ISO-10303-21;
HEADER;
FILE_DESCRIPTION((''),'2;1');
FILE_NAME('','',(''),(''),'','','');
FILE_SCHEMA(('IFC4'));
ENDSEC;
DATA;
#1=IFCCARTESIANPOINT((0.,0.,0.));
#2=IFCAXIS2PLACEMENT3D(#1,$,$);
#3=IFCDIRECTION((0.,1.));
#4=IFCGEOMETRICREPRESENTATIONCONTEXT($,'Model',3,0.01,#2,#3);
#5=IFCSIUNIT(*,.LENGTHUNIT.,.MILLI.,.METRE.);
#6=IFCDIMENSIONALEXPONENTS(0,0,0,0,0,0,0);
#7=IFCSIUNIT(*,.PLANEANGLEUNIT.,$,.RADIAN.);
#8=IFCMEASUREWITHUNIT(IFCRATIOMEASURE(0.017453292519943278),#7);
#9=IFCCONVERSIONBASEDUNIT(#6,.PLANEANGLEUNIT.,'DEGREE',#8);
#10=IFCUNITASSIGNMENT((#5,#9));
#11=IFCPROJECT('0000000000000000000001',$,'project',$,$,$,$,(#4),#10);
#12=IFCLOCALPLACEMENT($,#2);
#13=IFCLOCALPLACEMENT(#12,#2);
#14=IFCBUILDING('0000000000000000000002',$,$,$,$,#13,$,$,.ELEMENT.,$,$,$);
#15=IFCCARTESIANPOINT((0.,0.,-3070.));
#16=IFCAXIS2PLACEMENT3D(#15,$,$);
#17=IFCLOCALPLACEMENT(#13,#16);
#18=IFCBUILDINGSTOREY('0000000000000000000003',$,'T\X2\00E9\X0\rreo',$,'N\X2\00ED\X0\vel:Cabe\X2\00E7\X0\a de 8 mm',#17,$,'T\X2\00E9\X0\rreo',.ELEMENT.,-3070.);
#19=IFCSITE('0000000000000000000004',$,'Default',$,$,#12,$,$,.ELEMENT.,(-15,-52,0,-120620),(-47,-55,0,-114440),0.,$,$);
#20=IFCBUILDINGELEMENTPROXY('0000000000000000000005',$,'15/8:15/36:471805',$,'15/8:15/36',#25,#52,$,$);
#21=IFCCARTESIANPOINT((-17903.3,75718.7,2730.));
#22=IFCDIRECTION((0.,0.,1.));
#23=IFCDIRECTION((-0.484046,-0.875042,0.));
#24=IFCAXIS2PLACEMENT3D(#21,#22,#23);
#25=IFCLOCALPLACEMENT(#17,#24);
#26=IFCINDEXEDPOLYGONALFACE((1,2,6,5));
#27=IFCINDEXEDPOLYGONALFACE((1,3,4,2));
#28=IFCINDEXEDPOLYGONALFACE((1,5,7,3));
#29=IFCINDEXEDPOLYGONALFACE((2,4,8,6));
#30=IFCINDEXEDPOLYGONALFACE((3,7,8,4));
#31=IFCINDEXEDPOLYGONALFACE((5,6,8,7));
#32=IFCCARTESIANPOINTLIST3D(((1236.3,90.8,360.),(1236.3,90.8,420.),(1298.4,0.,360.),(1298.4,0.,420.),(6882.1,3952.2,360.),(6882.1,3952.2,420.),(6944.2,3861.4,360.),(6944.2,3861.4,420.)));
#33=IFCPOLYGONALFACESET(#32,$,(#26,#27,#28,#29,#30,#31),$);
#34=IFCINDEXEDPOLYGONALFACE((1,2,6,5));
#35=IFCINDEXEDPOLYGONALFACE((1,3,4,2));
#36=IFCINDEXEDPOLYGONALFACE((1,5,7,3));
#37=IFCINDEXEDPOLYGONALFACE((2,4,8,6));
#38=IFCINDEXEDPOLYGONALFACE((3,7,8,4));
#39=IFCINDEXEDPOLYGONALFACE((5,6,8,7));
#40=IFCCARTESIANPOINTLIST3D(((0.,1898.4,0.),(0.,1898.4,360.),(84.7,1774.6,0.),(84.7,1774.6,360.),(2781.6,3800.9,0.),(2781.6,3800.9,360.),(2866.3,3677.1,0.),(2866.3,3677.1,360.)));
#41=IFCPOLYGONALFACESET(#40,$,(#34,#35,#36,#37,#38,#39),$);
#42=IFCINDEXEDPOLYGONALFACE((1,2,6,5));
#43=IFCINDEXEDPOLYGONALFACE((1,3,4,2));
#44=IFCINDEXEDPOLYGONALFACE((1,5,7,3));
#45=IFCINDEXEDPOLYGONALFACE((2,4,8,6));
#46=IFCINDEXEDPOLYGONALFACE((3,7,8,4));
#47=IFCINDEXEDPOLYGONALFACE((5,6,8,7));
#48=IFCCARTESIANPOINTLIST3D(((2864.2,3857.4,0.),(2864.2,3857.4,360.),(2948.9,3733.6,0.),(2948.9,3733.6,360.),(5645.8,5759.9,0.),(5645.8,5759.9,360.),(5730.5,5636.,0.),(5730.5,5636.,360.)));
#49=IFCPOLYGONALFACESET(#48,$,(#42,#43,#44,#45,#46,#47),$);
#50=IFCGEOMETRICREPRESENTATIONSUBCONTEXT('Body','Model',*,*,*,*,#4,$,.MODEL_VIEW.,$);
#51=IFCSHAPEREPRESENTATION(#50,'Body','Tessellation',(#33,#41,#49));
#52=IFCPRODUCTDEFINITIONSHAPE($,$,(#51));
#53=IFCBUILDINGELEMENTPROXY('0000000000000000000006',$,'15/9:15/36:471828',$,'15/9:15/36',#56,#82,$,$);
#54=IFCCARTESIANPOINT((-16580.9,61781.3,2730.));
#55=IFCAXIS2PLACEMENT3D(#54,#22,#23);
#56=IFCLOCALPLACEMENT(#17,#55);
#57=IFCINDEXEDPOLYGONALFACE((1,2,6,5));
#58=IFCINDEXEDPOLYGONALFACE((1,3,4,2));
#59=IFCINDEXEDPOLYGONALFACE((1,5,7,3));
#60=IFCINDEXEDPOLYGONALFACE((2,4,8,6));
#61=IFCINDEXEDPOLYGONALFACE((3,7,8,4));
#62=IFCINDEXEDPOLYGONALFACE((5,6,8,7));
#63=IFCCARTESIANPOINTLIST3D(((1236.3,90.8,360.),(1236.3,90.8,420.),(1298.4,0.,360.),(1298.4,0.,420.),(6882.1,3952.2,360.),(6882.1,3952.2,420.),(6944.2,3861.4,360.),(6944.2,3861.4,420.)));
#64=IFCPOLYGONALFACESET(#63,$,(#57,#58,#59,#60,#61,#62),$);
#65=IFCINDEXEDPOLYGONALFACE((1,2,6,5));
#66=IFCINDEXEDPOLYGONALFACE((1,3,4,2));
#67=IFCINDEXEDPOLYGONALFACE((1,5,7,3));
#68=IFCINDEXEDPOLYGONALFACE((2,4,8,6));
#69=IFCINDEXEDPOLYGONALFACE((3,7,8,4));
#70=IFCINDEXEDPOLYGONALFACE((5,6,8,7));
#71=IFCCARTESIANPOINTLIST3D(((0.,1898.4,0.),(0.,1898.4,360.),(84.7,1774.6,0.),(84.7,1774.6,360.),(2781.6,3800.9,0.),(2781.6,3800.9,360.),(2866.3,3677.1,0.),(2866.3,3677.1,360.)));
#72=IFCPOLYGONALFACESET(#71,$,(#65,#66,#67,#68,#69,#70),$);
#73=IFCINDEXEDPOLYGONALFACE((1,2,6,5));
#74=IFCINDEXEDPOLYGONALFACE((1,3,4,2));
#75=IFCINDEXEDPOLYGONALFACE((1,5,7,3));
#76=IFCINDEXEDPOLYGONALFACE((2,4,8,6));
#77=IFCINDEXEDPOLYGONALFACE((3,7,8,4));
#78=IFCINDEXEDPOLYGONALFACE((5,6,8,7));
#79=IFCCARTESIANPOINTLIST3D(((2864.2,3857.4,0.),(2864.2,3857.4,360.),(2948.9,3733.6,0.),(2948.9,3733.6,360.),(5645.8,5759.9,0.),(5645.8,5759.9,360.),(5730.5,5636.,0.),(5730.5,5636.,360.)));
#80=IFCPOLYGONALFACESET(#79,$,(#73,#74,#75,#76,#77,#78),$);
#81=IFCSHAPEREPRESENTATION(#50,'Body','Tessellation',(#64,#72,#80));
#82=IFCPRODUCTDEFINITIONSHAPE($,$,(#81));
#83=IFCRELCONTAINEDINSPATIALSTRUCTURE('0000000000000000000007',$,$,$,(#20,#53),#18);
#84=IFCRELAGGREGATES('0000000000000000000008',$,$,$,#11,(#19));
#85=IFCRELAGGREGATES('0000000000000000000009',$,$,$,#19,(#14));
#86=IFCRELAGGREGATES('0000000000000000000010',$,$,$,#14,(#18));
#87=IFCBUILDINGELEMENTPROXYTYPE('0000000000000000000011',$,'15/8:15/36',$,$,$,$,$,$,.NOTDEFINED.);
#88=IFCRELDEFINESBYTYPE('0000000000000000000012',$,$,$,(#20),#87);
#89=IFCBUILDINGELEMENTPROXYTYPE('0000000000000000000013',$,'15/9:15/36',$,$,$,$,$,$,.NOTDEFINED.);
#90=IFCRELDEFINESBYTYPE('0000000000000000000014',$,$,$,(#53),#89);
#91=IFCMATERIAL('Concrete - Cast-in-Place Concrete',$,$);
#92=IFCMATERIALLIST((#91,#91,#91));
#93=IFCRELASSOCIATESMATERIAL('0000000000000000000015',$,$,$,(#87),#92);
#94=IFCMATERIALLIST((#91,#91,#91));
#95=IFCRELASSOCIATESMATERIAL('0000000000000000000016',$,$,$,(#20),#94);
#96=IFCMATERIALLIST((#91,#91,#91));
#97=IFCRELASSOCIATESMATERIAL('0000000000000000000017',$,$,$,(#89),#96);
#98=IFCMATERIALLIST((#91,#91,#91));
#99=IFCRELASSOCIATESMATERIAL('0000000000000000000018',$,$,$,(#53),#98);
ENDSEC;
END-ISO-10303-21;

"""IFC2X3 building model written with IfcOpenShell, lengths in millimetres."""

from ifc_helpers import new_model, entity, si_unit, converted_unit, direction, frame, frame_2d, origin, place, context, subcontext, project, spatial, rectangle, extrude, source, transform, mapped, material, material_list, type_object, type_shapes, element, save


model = new_model("IFC2X3")

# Units and contexts
model_context = context("Model", 3, precision=0.01, world=origin(), true_north=direction((0.0, 1.0)))
body_context = subcontext(model_context, "Body", "Model", "MODEL_VIEW")
ifc_project = project(units=[si_unit("LENGTHUNIT", "METRE", prefix="MILLI"), converted_unit("PLANEANGLEUNIT", "DEGREE", entity("IfcRatioMeasure", 0.017453292519943278), si_unit("PLANEANGLEUNIT", "RADIAN"), dimensions=[0, 0, 0, 0, 0, 0, 0])], contexts=[model_context])

# Site, building, storey
site_placement = place(None, origin())
site = spatial("IfcSite", under=ifc_project, at=site_placement, Name="Default", CompositionType="ELEMENT", RefLatitude=(-15, -52, 0, -120620), RefLongitude=(-47, -55, 0, -114440), RefElevation=0.0)
building_placement = place(site_placement, origin())
building = spatial("IfcBuilding", under=site, at=building_placement, CompositionType="ELEMENT")
storey_placement = place(building_placement, frame((0.0, 0.0, -3070.0)))
storey = spatial("IfcBuildingStorey", under=building, at=storey_placement, Name="Térreo", ObjectType="Nível:Cabeça de 8 mm", LongName="Térreo", CompositionType="ELEMENT", Elevation=-3070.0)

# Building element proxies
ifc_material_1 = material(Name="Concrete - Cast-in-Place Concrete")
ifc_material_list_1 = material_list([ifc_material_1, ifc_material_1, ifc_material_1])
ifc_material_list_2 = material_list([ifc_material_1, ifc_material_1, ifc_material_1])
building_element_proxy_type_1 = type_object("IfcBuildingElementProxyType", Name="15/8:15/36", PredefinedType="NOTDEFINED", material=ifc_material_list_2)
shared_shape_1 = source(origin(), body_context, "Body", "SweptSolid", [
    extrude(rectangle(XDim=110.0, YDim=6840.0, at=frame_2d((0.0, 0.0), x_axis=(1.0, 0.0))), frame((4090.3, 1976.1, 360.0), z_axis=(0.0, 0.0, 1.0), x_axis=(-0.564535, 0.825409, 0.0)), (0.0, 0.0, 1.0), 60.0),
    extrude(rectangle(XDim=3370.0, YDim=150.0, at=frame_2d((0.0, 0.0), x_axis=(1.0, 0.0))), frame((1433.2, 2787.8, 0.0), z_axis=(0.0, 0.0, 1.0), x_axis=(0.825409, 0.564535, 0.0)), (0.0, 0.0, 1.0), 360.0),
    extrude(rectangle(XDim=3370.0, YDim=150.0, at=frame_2d((0.0, 0.0), x_axis=(1.0, 0.0))), frame((4297.3, 4746.7, 0.0), z_axis=(0.0, 0.0, 1.0), x_axis=(0.825409, 0.564535, 0.0)), (0.0, 0.0, 1.0), 360.0),
])
type_shapes(building_element_proxy_type_1, [shared_shape_1])
proxy_1_placement = place(storey_placement, frame((-17903.3, 75718.7, 2730.0), z_axis=(0.0, 0.0, 1.0), x_axis=(-0.484046, -0.875042, 0.0)))
element("IfcBuildingElementProxy", 1, at=proxy_1_placement, inside=storey, type_object=building_element_proxy_type_1, material=ifc_material_list_1, Name="15/8:15/36:471805", ObjectType="15/8:15/36", context=body_context, shape_type="MappedRepresentation", body=[
    mapped(shared_shape_1, transform((0.0, 0.0, 0.0), scale=1.0)),
])
ifc_material_list_3 = material_list([ifc_material_1, ifc_material_1, ifc_material_1])
ifc_material_list_4 = material_list([ifc_material_1, ifc_material_1, ifc_material_1])
building_element_proxy_type_2 = type_object("IfcBuildingElementProxyType", Name="15/9:15/36", PredefinedType="NOTDEFINED", material=ifc_material_list_4)
shared_shape_2 = source(origin(), body_context, "Body", "SweptSolid", [
    extrude(rectangle(XDim=110.0, YDim=6840.0, at=frame_2d((0.0, 0.0), x_axis=(1.0, 0.0))), frame((4090.3, 1976.1, 360.0), z_axis=(0.0, 0.0, 1.0), x_axis=(-0.564535, 0.825409, 0.0)), (0.0, 0.0, 1.0), 60.0),
    extrude(rectangle(XDim=3370.0, YDim=150.0, at=frame_2d((0.0, 0.0), x_axis=(1.0, 0.0))), frame((1433.2, 2787.8, 0.0), z_axis=(0.0, 0.0, 1.0), x_axis=(0.825409, 0.564535, 0.0)), (0.0, 0.0, 1.0), 360.0),
    extrude(rectangle(XDim=3370.0, YDim=150.0, at=frame_2d((0.0, 0.0), x_axis=(1.0, 0.0))), frame((4297.3, 4746.7, 0.0), z_axis=(0.0, 0.0, 1.0), x_axis=(0.825409, 0.564535, 0.0)), (0.0, 0.0, 1.0), 360.0),
])
type_shapes(building_element_proxy_type_2, [shared_shape_2])
proxy_2_placement = place(storey_placement, frame((-16580.9, 61781.3, 2730.0), z_axis=(0.0, 0.0, 1.0), x_axis=(-0.484046, -0.875042, 0.0)))
element("IfcBuildingElementProxy", 2, at=proxy_2_placement, inside=storey, type_object=building_element_proxy_type_2, material=ifc_material_list_3, Name="15/9:15/36:471828", ObjectType="15/9:15/36", context=body_context, shape_type="MappedRepresentation", body=[
    mapped(shared_shape_2, transform((0.0, 0.0, 0.0), scale=1.0)),
])

save(model, "model.ifc")
